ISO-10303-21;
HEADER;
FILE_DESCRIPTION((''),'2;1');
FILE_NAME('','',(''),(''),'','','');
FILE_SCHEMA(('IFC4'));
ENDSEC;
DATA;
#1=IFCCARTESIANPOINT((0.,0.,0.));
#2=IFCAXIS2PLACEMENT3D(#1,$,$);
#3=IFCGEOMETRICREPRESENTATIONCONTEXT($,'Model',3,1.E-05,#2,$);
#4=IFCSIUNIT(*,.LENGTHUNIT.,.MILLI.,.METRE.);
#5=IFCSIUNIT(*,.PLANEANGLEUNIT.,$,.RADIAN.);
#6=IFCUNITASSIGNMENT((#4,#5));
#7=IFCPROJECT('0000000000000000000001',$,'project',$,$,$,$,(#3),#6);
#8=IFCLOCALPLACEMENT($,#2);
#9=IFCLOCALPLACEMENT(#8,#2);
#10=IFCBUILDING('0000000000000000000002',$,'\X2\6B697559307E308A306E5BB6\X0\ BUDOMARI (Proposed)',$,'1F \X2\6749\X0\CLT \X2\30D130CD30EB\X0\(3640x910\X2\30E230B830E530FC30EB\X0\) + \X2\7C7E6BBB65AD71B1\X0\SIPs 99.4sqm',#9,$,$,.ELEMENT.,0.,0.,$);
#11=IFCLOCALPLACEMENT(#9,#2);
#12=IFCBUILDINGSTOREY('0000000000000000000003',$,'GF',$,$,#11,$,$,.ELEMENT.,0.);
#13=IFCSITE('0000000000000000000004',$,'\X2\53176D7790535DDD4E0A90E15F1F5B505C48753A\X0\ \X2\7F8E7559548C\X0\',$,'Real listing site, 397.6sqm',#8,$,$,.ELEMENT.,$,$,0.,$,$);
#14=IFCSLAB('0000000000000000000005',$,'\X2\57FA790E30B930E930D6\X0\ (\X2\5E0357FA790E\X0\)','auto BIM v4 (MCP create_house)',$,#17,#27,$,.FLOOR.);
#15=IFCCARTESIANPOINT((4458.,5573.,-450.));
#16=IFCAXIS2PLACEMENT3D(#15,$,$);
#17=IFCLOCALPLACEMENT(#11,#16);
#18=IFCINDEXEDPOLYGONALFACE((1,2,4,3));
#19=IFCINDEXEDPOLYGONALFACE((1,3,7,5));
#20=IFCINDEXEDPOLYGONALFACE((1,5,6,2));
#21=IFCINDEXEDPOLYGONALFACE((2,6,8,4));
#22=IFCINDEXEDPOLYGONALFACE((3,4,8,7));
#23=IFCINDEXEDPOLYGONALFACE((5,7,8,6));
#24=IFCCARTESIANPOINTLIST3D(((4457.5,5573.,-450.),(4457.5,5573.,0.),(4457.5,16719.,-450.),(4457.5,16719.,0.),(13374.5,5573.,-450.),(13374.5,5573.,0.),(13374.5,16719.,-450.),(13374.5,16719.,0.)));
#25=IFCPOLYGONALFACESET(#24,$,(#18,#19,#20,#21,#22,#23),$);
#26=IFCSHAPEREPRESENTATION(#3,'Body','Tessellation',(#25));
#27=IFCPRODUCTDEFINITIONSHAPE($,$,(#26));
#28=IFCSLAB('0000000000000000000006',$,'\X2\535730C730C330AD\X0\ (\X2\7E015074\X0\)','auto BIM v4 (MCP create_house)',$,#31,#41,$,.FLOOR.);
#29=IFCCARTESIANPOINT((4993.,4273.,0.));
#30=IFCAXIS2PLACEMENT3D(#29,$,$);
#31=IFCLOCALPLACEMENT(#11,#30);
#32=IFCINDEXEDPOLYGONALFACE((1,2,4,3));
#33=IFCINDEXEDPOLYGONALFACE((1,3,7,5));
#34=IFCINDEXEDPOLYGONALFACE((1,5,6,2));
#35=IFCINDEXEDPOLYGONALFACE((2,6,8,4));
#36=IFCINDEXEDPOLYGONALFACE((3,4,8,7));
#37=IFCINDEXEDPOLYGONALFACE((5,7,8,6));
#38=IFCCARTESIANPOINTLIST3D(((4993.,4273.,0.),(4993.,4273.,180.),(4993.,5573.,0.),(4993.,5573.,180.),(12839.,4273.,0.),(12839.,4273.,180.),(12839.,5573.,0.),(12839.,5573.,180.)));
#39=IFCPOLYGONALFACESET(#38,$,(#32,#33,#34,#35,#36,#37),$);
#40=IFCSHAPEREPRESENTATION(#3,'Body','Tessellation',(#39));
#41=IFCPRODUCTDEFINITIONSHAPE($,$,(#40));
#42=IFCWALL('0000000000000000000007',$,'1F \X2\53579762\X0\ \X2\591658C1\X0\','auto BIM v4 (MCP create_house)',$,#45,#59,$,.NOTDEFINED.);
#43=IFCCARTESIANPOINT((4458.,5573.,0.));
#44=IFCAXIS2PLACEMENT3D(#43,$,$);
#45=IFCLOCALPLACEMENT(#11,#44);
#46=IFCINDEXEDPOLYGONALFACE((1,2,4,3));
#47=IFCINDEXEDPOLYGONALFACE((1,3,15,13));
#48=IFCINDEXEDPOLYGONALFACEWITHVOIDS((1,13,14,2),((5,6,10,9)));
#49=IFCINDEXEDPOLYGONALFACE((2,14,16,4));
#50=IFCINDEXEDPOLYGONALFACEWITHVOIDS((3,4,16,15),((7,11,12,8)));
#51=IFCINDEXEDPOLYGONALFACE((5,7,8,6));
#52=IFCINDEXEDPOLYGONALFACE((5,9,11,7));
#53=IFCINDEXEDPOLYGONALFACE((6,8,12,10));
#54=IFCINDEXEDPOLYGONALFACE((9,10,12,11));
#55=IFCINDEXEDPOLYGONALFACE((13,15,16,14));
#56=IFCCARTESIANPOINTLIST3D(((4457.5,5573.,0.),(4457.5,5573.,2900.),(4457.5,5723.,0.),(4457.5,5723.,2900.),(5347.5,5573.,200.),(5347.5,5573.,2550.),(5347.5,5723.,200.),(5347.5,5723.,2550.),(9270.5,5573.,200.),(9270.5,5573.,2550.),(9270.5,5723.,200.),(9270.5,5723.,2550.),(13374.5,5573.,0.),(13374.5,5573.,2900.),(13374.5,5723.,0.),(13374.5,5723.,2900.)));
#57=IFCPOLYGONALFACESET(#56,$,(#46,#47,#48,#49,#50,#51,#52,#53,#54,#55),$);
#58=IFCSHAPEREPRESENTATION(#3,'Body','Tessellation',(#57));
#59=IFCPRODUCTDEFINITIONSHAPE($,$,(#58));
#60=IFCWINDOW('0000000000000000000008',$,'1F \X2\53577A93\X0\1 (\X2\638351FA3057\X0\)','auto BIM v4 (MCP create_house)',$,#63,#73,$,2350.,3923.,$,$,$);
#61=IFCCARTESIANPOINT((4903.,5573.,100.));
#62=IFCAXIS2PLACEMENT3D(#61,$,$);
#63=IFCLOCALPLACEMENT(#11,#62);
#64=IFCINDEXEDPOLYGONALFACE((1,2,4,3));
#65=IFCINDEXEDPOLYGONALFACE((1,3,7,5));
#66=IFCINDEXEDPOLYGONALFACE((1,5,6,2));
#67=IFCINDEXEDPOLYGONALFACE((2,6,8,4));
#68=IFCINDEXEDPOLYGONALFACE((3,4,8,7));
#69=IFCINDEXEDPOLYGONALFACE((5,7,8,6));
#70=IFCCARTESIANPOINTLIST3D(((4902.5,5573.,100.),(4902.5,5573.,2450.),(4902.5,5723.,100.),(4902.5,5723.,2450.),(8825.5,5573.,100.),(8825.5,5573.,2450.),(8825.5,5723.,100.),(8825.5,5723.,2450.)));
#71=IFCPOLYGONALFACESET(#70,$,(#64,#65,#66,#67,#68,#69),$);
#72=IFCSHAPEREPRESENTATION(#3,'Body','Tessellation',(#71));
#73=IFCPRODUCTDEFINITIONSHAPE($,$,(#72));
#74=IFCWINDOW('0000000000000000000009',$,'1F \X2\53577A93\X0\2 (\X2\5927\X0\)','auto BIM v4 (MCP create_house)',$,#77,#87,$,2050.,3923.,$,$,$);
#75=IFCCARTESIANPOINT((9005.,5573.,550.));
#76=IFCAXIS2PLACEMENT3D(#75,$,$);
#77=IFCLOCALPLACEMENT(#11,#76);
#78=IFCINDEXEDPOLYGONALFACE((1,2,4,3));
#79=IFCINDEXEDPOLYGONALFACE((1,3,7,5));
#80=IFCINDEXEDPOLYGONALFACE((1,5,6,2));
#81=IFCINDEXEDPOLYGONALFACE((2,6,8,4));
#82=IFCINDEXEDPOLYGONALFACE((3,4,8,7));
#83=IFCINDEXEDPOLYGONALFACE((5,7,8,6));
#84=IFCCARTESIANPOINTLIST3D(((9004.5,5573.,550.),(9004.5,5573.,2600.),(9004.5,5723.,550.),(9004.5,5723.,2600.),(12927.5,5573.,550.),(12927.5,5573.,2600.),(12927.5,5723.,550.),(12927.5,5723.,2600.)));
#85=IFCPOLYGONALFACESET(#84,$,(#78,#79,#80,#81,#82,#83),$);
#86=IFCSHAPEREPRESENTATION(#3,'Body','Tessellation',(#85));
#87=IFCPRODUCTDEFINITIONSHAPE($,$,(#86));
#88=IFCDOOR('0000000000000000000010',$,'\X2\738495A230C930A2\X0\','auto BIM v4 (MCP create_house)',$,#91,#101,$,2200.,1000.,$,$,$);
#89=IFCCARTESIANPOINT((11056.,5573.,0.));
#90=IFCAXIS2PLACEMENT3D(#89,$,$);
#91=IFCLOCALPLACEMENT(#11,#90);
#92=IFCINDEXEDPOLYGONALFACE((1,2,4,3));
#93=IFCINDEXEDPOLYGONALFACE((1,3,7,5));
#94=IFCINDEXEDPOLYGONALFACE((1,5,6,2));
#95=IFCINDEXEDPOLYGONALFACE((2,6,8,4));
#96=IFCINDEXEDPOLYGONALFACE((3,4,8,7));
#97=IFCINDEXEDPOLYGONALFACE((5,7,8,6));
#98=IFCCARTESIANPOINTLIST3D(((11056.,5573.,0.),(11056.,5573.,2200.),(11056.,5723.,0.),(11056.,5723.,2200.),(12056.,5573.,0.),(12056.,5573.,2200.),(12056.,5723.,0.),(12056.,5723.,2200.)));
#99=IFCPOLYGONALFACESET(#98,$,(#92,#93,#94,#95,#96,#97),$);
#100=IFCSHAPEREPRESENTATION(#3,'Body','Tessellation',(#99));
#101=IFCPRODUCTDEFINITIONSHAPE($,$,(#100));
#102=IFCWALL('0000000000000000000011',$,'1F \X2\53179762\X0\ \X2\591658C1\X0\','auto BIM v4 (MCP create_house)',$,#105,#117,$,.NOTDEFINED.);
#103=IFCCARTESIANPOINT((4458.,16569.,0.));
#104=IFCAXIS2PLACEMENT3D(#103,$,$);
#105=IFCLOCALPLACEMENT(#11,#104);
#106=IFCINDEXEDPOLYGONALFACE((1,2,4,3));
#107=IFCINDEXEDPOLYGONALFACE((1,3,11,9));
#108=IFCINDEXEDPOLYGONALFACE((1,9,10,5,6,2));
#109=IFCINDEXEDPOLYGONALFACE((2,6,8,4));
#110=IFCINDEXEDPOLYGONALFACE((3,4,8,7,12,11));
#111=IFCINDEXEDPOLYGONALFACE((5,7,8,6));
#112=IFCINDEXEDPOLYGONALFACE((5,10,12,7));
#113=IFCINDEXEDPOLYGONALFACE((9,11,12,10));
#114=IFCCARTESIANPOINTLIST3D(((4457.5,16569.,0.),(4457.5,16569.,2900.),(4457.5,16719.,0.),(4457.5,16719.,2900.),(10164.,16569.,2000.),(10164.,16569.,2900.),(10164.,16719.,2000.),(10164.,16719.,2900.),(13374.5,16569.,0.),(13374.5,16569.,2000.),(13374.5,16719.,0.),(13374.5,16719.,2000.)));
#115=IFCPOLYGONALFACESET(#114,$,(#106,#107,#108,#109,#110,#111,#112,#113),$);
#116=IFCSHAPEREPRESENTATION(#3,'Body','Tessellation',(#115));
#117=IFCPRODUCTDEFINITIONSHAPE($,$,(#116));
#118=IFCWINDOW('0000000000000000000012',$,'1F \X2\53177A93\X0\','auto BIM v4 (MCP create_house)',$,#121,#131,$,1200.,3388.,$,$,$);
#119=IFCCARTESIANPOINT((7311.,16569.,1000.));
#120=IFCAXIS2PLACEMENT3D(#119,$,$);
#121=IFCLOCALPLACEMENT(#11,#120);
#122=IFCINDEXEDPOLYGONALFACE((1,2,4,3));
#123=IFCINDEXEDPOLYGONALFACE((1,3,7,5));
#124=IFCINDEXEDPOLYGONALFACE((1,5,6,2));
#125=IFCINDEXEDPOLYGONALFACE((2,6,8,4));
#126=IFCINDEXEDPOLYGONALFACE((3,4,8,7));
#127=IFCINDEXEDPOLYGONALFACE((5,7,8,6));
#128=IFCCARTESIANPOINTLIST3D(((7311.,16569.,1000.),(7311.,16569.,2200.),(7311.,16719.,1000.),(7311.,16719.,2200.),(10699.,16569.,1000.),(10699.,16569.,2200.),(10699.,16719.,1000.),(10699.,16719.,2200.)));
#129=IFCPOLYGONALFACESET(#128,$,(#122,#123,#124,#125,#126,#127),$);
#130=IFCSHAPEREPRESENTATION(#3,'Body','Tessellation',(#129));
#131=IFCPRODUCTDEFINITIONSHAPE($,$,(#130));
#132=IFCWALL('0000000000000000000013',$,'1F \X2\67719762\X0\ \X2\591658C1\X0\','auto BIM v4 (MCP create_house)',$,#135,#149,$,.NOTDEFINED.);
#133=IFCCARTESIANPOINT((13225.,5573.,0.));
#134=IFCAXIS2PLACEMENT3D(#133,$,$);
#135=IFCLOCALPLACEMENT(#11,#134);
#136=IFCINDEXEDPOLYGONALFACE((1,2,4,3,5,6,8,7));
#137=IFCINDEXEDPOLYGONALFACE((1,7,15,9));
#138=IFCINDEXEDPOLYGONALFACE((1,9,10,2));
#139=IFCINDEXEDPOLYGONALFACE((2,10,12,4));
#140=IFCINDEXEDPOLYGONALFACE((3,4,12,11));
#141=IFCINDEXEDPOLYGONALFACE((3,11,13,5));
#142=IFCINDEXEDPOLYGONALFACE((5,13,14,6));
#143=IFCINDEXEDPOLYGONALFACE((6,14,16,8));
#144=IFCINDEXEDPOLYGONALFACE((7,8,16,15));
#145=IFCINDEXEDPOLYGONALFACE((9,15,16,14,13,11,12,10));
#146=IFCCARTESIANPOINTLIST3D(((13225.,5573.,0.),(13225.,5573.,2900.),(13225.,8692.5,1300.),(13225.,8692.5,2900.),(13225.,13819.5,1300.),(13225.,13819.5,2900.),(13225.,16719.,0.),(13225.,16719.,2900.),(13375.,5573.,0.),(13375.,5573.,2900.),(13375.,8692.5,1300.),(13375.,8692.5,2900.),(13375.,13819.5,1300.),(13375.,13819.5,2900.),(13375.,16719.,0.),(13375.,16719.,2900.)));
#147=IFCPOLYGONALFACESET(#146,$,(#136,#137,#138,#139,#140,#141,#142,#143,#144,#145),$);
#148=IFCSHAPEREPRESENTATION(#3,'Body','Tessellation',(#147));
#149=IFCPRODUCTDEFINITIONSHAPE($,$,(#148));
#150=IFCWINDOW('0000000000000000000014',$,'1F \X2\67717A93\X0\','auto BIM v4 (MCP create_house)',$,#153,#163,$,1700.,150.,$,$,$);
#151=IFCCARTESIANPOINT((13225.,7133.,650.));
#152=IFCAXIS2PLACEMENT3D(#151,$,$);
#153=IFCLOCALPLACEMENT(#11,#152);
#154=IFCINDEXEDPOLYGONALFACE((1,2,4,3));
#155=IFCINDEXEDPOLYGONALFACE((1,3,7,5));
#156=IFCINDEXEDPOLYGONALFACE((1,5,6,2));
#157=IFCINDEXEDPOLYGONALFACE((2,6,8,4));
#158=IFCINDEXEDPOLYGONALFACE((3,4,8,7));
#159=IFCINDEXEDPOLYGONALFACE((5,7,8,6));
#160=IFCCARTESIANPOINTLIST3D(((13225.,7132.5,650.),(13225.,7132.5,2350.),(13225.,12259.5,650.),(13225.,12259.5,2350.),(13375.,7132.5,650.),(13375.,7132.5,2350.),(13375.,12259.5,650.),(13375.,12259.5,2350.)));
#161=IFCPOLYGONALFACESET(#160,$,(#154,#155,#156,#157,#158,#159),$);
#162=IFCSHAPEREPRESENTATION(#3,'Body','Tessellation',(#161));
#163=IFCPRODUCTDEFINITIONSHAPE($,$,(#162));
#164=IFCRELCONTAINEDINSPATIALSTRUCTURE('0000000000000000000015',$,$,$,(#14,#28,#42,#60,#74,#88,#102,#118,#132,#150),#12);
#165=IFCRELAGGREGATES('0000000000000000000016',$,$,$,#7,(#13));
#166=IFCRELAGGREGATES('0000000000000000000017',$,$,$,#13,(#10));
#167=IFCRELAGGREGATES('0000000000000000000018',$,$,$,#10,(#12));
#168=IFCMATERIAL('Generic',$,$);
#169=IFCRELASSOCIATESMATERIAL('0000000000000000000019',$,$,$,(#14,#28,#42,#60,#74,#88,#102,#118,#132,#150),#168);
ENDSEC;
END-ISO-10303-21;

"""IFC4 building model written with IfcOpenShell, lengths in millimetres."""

from ifc_helpers import new_model, si_unit, frame, frame_2d, origin, place, context, project, spatial, rectangle, extrude, material, element, fill, save


model = new_model("IFC4")

# Units and contexts
model_context = context("Model", 3, precision=1e-05, world=origin())
ifc_project = project(units=[si_unit("LENGTHUNIT", "METRE", prefix="MILLI"), si_unit("PLANEANGLEUNIT", "RADIAN")], contexts=[model_context])

# Site, building, storey
site_placement = place(None, origin())
site = spatial("IfcSite", under=ifc_project, at=site_placement, Name="北海道川上郡弟子屈町 美留和", ObjectType="Real listing site, 397.6sqm", CompositionType="ELEMENT", RefElevation=0.0)
building_placement = place(site_placement, origin())
building = spatial("IfcBuilding", under=site, at=building_placement, Name="歩留まりの家 BUDOMARI (Proposed)", ObjectType="1F 杉CLT パネル(3640x910モジュール) + 籾殻断熱SIPs 99.4sqm", CompositionType="ELEMENT", ElevationOfRefHeight=0.0, ElevationOfTerrain=0.0)
storey_placement = place(building_placement, origin())
storey = spatial("IfcBuildingStorey", under=building, at=storey_placement, Name="GF", CompositionType="ELEMENT", Elevation=0.0)

# Slabs
ifc_material = material(Name="Generic")
slab_1_placement = place(storey_placement, frame((4458.0, 5573.0, -450.0)))
element("IfcSlab", 1, at=slab_1_placement, inside=storey, material=ifc_material, Name="基礎スラブ (布基礎)", Description="auto BIM v4 (MCP create_house)", PredefinedType="FLOOR", context=model_context, shape_type="SweptSolid", body=[
    extrude(rectangle(XDim=8917.0, YDim=11146.0, at=frame_2d((4458.0, 5573.0))), frame((4458.0, 5573.0, -450.0)), (0.0, 0.0, 1.0), 450.0),
])
slab_2_placement = place(storey_placement, frame((4993.0, 4273.0, 0.0)))
element("IfcSlab", 2, at=slab_2_placement, inside=storey, material=ifc_material, Name="南デッキ (縁側)", Description="auto BIM v4 (MCP create_house)", PredefinedType="FLOOR", context=model_context, shape_type="SweptSolid", body=[
    extrude(rectangle(XDim=7846.0, YDim=1300.0, at=frame_2d((3923.0, 650.0))), frame((4993.0, 4273.0, 0.0)), (0.0, 0.0, 1.0), 180.0),
])

# Wall, openings, windows, door
wall_1_placement = place(storey_placement, frame((4458.0, 5573.0, 0.0)))
wall_1 = element("IfcWall", 3, at=wall_1_placement, inside=storey, material=ifc_material, Name="1F 南面 外壁", Description="auto BIM v4 (MCP create_house)", PredefinedType="NOTDEFINED", context=model_context, shape_type="SweptSolid", body=[
    extrude(rectangle(XDim=8917.0, YDim=150.0, at=frame_2d((4458.0, 75.0))), frame((4458.0, 5573.0, 0.0)), (0.0, 0.0, 1.0), 2900.0),
])
opening_1_placement = place(storey_placement, frame((4903.0, 5573.0, 100.0)))
opening_1 = element("IfcOpeningElement", 4, at=opening_1_placement, cuts=wall_1, PredefinedType="NOTDEFINED", context=model_context, shape_type="SweptSolid", body=[
    extrude(rectangle(XDim=3923.0, YDim=150.0, at=frame_2d((1961.0, 75.0))), frame((4903.0, 5573.0, 100.0)), (0.0, 0.0, 1.0), 2350.0),
])
opening_2_placement = place(storey_placement, frame((9005.0, 5573.0, 550.0)))
opening_2 = element("IfcOpeningElement", 5, at=opening_2_placement, cuts=wall_1, PredefinedType="NOTDEFINED", context=model_context, shape_type="SweptSolid", body=[
    extrude(rectangle(XDim=3923.0, YDim=150.0, at=frame_2d((1961.0, 75.0))), frame((9005.0, 5573.0, 550.0)), (0.0, 0.0, 1.0), 2050.0),
])
opening_3_placement = place(storey_placement, frame((11056.0, 5573.0, 0.0)))
opening_3 = element("IfcOpeningElement", 6, at=opening_3_placement, cuts=wall_1, PredefinedType="NOTDEFINED", context=model_context, shape_type="SweptSolid", body=[
    extrude(rectangle(XDim=1000.0, YDim=150.0, at=frame_2d((500.0, 75.0))), frame((11056.0, 5573.0, 0.0)), (0.0, 0.0, 1.0), 2200.0),
])
window_1_placement = place(storey_placement, frame((4903.0, 5573.0, 100.0)))
window_1 = element("IfcWindow", 7, at=window_1_placement, inside=storey, material=ifc_material, Name="1F 南窓1 (掃出し)", Description="auto BIM v4 (MCP create_house)", OverallHeight=2350.0, OverallWidth=3923.0, context=model_context, shape_type="SweptSolid", body=[
    extrude(rectangle(XDim=3923.0, YDim=150.0, at=frame_2d((1961.0, 75.0))), frame((4903.0, 5573.0, 100.0)), (0.0, 0.0, 1.0), 2350.0),
])
fill(opening_1, window_1)
window_2_placement = place(storey_placement, frame((9005.0, 5573.0, 550.0)))
window_2 = element("IfcWindow", 8, at=window_2_placement, inside=storey, material=ifc_material, Name="1F 南窓2 (大)", Description="auto BIM v4 (MCP create_house)", OverallHeight=2050.0, OverallWidth=3923.0, context=model_context, shape_type="SweptSolid", body=[
    extrude(rectangle(XDim=3923.0, YDim=150.0, at=frame_2d((1961.0, 75.0))), frame((9005.0, 5573.0, 550.0)), (0.0, 0.0, 1.0), 2050.0),
])
fill(opening_2, window_2)
door_placement = place(storey_placement, frame((11056.0, 5573.0, 0.0)))
door = element("IfcDoor", 9, at=door_placement, inside=storey, material=ifc_material, Name="玄関ドア", Description="auto BIM v4 (MCP create_house)", OverallHeight=2200.0, OverallWidth=1000.0, context=model_context, shape_type="SweptSolid", body=[
    extrude(rectangle(XDim=1000.0, YDim=150.0, at=frame_2d((500.0, 75.0))), frame((11056.0, 5573.0, 0.0)), (0.0, 0.0, 1.0), 2200.0),
])
fill(opening_3, door)

# Walls, openings, windows
wall_2_placement = place(storey_placement, frame((4458.0, 16569.0, 0.0)))
wall_2 = element("IfcWall", 10, at=wall_2_placement, inside=storey, material=ifc_material, Name="1F 北面 外壁", Description="auto BIM v4 (MCP create_house)", PredefinedType="NOTDEFINED", context=model_context, shape_type="SweptSolid", body=[
    extrude(rectangle(XDim=8917.0, YDim=150.0, at=frame_2d((4458.0, 75.0))), frame((4458.0, 16569.0, 0.0)), (0.0, 0.0, 1.0), 2900.0),
])
opening_4_placement = place(storey_placement, frame((7311.0, 16569.0, 1000.0)))
opening_4 = element("IfcOpeningElement", 11, at=opening_4_placement, cuts=wall_2, PredefinedType="NOTDEFINED", context=model_context, shape_type="SweptSolid", body=[
    extrude(rectangle(XDim=3388.0, YDim=150.0, at=frame_2d((1694.0, 75.0))), frame((7311.0, 16569.0, 1000.0)), (0.0, 0.0, 1.0), 1200.0),
])
window_3_placement = place(storey_placement, frame((7311.0, 16569.0, 1000.0)))
window_3 = element("IfcWindow", 12, at=window_3_placement, inside=storey, material=ifc_material, Name="1F 北窓", Description="auto BIM v4 (MCP create_house)", OverallHeight=1200.0, OverallWidth=3388.0, context=model_context, shape_type="SweptSolid", body=[
    extrude(rectangle(XDim=3388.0, YDim=150.0, at=frame_2d((1694.0, 75.0))), frame((7311.0, 16569.0, 1000.0)), (0.0, 0.0, 1.0), 1200.0),
])
fill(opening_4, window_3)
wall_3_placement = place(storey_placement, frame((13225.0, 5573.0, 0.0)))
wall_3 = element("IfcWall", 13, at=wall_3_placement, inside=storey, material=ifc_material, Name="1F 東面 外壁", Description="auto BIM v4 (MCP create_house)", PredefinedType="NOTDEFINED", context=model_context, shape_type="SweptSolid", body=[
    extrude(rectangle(XDim=150.0, YDim=11146.0, at=frame_2d((75.0, 5573.0))), frame((13225.0, 5573.0, 0.0)), (0.0, 0.0, 1.0), 2900.0),
])
opening_5_placement = place(storey_placement, frame((13225.0, 7133.0, 650.0)))
opening_5 = element("IfcOpeningElement", 14, at=opening_5_placement, cuts=wall_3, PredefinedType="NOTDEFINED", context=model_context, shape_type="SweptSolid", body=[
    extrude(rectangle(XDim=150.0, YDim=5127.0, at=frame_2d((75.0, 2563.0))), frame((13225.0, 7133.0, 650.0)), (0.0, 0.0, 1.0), 1700.0),
])
window_4_placement = place(storey_placement, frame((13225.0, 7133.0, 650.0)))
window_4 = element("IfcWindow", 15, at=window_4_placement, inside=storey, material=ifc_material, Name="1F 東窓", Description="auto BIM v4 (MCP create_house)", OverallHeight=1700.0, OverallWidth=150.0, context=model_context, shape_type="SweptSolid", body=[
    extrude(rectangle(XDim=150.0, YDim=5127.0, at=frame_2d((75.0, 2563.0))), frame((13225.0, 7133.0, 650.0)), (0.0, 0.0, 1.0), 1700.0),
])
fill(opening_5, window_4)

save(model, "model.ifc")
